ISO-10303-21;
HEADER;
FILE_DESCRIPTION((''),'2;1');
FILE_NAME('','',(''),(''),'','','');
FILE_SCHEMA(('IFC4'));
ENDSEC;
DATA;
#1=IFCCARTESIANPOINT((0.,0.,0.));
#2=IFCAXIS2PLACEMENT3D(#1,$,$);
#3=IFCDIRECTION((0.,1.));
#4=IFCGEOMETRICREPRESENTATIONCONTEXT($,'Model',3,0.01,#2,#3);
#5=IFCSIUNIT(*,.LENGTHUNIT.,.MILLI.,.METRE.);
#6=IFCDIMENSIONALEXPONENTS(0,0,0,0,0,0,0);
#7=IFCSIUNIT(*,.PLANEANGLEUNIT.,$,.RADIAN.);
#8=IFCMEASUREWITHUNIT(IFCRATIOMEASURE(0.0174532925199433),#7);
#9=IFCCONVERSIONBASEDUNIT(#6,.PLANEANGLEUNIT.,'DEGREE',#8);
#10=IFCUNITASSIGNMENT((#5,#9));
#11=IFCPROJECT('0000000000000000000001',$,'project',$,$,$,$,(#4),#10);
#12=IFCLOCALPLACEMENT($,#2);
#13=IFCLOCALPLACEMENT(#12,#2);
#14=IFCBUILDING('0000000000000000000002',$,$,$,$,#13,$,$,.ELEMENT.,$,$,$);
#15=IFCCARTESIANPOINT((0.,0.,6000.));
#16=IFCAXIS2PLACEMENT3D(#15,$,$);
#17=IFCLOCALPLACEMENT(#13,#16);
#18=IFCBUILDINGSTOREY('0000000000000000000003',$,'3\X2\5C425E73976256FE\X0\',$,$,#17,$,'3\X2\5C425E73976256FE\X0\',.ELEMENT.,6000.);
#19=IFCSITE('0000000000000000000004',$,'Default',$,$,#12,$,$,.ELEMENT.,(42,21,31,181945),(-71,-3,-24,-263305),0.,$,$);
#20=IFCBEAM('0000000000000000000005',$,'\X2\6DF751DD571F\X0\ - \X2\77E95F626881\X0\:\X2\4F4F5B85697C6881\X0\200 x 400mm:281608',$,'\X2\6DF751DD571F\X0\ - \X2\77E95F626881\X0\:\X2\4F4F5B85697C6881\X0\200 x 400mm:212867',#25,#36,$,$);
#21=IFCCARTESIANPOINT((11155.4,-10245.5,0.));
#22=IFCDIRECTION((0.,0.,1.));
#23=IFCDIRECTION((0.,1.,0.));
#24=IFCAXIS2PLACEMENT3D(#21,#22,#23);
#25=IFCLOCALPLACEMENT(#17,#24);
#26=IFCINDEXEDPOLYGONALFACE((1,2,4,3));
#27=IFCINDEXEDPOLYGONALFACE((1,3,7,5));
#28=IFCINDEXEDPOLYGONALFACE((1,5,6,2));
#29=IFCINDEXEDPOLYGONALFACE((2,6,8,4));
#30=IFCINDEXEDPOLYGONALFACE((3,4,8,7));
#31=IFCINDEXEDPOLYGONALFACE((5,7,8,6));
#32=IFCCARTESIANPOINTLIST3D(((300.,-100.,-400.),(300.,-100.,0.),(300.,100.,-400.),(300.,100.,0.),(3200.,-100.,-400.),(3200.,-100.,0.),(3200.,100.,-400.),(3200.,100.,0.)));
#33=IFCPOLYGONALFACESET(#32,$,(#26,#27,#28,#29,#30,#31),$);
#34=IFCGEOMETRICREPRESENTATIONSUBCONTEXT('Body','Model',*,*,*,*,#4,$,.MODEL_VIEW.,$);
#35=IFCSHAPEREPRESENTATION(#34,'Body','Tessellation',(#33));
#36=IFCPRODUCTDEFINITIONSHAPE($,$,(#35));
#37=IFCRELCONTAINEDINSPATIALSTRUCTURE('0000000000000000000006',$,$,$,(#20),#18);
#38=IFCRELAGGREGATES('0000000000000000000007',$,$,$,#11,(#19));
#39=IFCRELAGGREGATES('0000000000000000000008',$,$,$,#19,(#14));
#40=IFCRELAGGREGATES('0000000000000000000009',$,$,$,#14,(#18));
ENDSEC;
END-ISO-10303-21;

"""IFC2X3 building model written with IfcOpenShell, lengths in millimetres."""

from ifc_helpers import new_model, entity, si_unit, converted_unit, direction, frame, frame_2d, origin, place, context, subcontext, project, spatial, rectangle, extrude, element, save


model = new_model("IFC2X3")

# Units and contexts
model_context = context("Model", 3, precision=0.01, world=origin(), true_north=direction((0.0, 1.0)))
body_context = subcontext(model_context, "Body", "Model", "MODEL_VIEW")
ifc_project = project(units=[si_unit("LENGTHUNIT", "METRE", prefix="MILLI"), converted_unit("PLANEANGLEUNIT", "DEGREE", entity("IfcRatioMeasure", 0.0174532925199433), si_unit("PLANEANGLEUNIT", "RADIAN"), dimensions=[0, 0, 0, 0, 0, 0, 0])], contexts=[model_context])

# Site, building, storey
site_placement = place(None, origin())
site = spatial("IfcSite", under=ifc_project, at=site_placement, Name="Default", CompositionType="ELEMENT", RefLatitude=(42, 21, 31, 181945), RefLongitude=(-71, -3, -24, -263305), RefElevation=0.0)
building_placement = place(site_placement, origin())
building = spatial("IfcBuilding", under=site, at=building_placement, CompositionType="ELEMENT")
storey_placement = place(building_placement, frame((0.0, 0.0, 6000.0)))
storey = spatial("IfcBuildingStorey", under=building, at=storey_placement, Name="3层平面图", LongName="3层平面图", CompositionType="ELEMENT", Elevation=6000.0)

# Beam
beam_1_placement = place(storey_placement, frame((11155.4, -10245.5, 0.0), z_axis=(0.0, 0.0, 1.0), x_axis=(0.0, 1.0, 0.0)))
element("IfcBeam", 1, at=beam_1_placement, inside=storey, Name="混凝土 - 矩形梁:住宅楼梁200 x 400mm:281608", ObjectType="混凝土 - 矩形梁:住宅楼梁200 x 400mm:212867", context=body_context, shape_type="SweptSolid", body=[
    extrude(rectangle(XDim=400.0, YDim=200.0, at=frame_2d((0.0, 0.0), x_axis=(1.0, 0.0))), frame((300.0, 0.0, -200.0), z_axis=(1.0, 0.0, 0.0), x_axis=(0.0, 0.0, -1.0)), (0.0, 0.0, 1.0), 2900.0),
])

save(model, "model.ifc")
